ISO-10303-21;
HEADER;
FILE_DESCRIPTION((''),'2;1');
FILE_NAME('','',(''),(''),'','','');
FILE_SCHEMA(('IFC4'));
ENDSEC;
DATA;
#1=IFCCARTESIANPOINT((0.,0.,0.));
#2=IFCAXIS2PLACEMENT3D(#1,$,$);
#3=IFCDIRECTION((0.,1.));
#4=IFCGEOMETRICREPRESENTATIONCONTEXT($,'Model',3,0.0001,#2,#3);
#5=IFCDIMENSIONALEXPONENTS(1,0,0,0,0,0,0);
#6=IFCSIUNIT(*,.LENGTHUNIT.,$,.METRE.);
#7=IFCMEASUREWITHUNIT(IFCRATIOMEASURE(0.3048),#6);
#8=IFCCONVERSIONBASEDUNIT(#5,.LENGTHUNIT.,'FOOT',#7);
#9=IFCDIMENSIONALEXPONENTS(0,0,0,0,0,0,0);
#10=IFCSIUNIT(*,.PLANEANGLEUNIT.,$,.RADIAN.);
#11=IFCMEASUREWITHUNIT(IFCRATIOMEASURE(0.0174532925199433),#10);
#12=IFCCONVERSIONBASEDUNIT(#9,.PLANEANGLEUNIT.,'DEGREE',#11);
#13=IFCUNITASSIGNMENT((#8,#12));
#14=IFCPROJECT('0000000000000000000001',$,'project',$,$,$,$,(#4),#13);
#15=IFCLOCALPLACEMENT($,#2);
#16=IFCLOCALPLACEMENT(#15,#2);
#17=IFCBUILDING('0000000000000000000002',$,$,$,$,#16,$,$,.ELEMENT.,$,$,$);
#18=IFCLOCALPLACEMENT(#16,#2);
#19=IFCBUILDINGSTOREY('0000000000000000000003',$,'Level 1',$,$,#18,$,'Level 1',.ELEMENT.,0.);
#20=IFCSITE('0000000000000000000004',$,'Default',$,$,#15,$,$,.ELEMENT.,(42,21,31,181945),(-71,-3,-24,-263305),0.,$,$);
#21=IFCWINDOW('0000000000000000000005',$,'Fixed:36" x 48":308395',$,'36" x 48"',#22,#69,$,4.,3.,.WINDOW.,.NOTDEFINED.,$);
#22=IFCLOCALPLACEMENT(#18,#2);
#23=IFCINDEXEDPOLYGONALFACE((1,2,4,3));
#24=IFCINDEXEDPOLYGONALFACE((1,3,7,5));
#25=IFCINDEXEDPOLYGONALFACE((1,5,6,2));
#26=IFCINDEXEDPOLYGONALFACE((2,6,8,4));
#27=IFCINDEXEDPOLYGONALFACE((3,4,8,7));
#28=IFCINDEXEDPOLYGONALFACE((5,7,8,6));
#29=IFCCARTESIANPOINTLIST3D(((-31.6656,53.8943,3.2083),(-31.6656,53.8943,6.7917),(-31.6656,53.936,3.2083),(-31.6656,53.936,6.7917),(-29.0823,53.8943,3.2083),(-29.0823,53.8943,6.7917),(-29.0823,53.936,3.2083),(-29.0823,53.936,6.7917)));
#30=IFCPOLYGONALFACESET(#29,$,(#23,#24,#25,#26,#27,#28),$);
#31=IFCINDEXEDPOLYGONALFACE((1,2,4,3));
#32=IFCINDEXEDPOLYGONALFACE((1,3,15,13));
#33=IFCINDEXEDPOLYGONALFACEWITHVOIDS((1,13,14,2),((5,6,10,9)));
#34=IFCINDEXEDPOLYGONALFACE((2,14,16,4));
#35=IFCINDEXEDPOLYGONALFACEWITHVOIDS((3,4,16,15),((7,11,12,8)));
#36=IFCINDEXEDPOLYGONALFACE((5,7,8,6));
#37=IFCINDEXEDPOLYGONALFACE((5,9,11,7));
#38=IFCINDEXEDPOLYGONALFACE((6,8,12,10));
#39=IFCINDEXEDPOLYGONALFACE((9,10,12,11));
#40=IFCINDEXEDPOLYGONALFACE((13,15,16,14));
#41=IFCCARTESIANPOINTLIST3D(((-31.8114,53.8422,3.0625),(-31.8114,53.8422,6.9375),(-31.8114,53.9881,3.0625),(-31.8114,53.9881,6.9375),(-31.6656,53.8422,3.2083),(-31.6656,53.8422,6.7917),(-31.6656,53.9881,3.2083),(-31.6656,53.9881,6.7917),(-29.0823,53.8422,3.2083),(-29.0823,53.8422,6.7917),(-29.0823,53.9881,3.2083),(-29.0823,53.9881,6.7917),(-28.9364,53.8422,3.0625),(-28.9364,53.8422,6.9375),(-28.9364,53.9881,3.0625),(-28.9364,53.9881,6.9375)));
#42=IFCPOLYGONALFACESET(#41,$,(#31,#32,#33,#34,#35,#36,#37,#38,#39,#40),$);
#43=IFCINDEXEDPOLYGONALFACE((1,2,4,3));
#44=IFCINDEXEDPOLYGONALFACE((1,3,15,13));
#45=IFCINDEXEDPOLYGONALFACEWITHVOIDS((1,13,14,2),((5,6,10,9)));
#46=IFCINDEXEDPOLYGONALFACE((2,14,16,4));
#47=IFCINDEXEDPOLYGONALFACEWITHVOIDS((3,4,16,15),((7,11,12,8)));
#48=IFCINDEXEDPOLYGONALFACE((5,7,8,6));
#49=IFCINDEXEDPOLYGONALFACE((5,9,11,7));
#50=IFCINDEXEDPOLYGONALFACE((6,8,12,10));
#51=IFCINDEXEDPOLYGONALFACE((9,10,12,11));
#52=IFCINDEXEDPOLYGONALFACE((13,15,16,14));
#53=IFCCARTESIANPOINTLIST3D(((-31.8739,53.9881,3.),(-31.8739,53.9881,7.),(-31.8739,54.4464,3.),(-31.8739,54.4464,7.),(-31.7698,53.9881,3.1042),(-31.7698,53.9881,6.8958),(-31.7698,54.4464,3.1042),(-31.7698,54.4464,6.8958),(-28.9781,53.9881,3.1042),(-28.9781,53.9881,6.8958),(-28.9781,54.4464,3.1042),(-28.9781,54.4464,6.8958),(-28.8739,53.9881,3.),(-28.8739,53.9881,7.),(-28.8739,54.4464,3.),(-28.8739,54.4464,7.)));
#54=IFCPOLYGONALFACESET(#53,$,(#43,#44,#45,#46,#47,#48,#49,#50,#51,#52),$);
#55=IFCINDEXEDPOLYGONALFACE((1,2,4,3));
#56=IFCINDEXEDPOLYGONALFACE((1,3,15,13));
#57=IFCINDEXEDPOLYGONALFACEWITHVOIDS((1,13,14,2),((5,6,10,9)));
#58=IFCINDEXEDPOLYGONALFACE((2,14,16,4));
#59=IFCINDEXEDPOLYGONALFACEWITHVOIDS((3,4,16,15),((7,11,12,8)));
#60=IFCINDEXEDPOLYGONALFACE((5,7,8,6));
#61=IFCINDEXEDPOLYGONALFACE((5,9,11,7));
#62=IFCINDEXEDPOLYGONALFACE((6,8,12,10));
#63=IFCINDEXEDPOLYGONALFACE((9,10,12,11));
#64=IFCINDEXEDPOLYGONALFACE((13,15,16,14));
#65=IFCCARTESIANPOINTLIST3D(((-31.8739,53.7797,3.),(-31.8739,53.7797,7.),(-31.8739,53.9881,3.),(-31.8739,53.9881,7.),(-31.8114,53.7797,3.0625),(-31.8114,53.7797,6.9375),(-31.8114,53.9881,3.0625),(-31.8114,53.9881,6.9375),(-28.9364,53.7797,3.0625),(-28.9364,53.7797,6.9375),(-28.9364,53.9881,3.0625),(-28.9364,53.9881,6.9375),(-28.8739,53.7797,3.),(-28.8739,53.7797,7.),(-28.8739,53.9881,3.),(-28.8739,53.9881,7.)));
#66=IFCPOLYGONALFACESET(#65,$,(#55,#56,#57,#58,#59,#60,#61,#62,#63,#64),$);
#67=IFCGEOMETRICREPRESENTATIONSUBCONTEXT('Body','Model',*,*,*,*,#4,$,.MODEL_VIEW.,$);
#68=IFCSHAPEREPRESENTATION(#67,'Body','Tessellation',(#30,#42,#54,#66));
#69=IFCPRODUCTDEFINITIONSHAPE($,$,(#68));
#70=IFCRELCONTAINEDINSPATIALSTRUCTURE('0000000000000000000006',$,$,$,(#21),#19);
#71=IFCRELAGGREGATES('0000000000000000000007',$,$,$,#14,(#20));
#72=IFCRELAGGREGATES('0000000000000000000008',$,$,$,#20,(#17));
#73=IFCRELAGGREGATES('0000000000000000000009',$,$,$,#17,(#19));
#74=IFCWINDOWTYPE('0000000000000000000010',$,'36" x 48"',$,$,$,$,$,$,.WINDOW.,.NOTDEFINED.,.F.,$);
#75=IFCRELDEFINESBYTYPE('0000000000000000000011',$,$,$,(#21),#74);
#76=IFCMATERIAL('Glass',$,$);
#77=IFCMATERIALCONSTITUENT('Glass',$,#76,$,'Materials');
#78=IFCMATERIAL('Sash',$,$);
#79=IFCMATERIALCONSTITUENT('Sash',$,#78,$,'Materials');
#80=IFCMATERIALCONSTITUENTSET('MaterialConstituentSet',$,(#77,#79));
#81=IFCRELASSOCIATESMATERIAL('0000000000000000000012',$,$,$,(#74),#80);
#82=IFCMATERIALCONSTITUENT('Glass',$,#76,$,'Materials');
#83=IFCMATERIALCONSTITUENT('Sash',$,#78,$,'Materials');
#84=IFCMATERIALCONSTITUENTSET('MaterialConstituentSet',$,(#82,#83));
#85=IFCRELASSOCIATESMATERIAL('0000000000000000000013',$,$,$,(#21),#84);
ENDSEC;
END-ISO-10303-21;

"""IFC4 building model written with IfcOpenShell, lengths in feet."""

from ifc_helpers import new_model, entity, si_unit, converted_unit, direction, frame, frame_2d, origin, place, context, subcontext, project, spatial, polyline, rectangle, outline, extrude, source, transform, mapped, material, constituent, constituent_set, type_object, type_shapes, element, save


model = new_model("IFC4")

# Units and contexts
model_context = context("Model", 3, precision=0.0001, world=origin(), true_north=direction((0.0, 1.0)))
body_context = subcontext(model_context, "Body", "Model", "MODEL_VIEW")
ifc_project = project(units=[converted_unit("LENGTHUNIT", "FOOT", entity("IfcRatioMeasure", 0.3048), si_unit("LENGTHUNIT", "METRE"), dimensions=[1, 0, 0, 0, 0, 0, 0]), converted_unit("PLANEANGLEUNIT", "DEGREE", entity("IfcRatioMeasure", 0.0174532925199433), si_unit("PLANEANGLEUNIT", "RADIAN"), dimensions=[0, 0, 0, 0, 0, 0, 0])], contexts=[model_context])

# Site, building, storey
site_placement = place(None, origin())
site = spatial("IfcSite", under=ifc_project, at=site_placement, Name="Default", CompositionType="ELEMENT", RefLatitude=(42, 21, 31, 181945), RefLongitude=(-71, -3, -24, -263305), RefElevation=0.0)
building_placement = place(site_placement, origin())
building = spatial("IfcBuilding", under=site, at=building_placement, CompositionType="ELEMENT")
storey_placement = place(building_placement, origin())
storey = spatial("IfcBuildingStorey", under=building, at=storey_placement, Name="Level 1", LongName="Level 1", CompositionType="ELEMENT", Elevation=0.0)

# Shared definitions
placement_1 = place(storey_placement, frame((-39.4573, 54.1131, 0.0)))

# Window
ifc_material_1 = material(Name="Glass")
ifc_constituent_1 = constituent(ifc_material_1, Name="Glass", Category="Materials")
ifc_material_2 = material(Name="Sash")
ifc_constituent_2 = constituent(ifc_material_2, Name="Sash", Category="Materials")
ifc_constituent_set_1 = constituent_set(constituents=[ifc_constituent_1, ifc_constituent_2], Name="MaterialConstituentSet")
ifc_constituent_3 = constituent(ifc_material_1, Name="Glass", Category="Materials")
ifc_constituent_4 = constituent(ifc_material_2, Name="Sash", Category="Materials")
ifc_constituent_set_2 = constituent_set(constituents=[ifc_constituent_3, ifc_constituent_4], Name="MaterialConstituentSet")
window_type = type_object("IfcWindowType", Name="36\" x 48\"", ParameterTakesPrecedence=False, PartitioningType="NOTDEFINED", PredefinedType="WINDOW", material=ifc_constituent_set_2)
shared_shape = source(origin(), body_context, "Body", "SweptSolid", [
    extrude(rectangle(XDim=0.0417, YDim=2.5833, at=frame_2d((0.0, 0.0), x_axis=(1.0, 0.0))), frame((1.5, 0.5312, 0.2083), z_axis=(0.0, 0.0, 1.0), x_axis=(0.0, 1.0, 0.0)), (0.0, 0.0, 1.0), 3.5833),
    extrude(outline(polyline([(-1.4375, -1.9375), (1.4375, -1.9375), (1.4375, 1.9375), (-1.4375, 1.9375), (-1.4375, -1.9375)]), holes=[polyline([(-1.2917, -1.7917), (-1.2917, 1.7917), (1.2917, 1.7917), (1.2917, -1.7917), (-1.2917, -1.7917)])]), frame((1.5, 0.4583, 2.0), z_axis=(0.0, 1.0, 0.0), x_axis=(1.0, 0.0, 0.0)), (0.0, 0.0, 1.0), 0.1458),
    extrude(outline(polyline([(-1.5, -2.0), (1.5, -2.0), (1.5, 2.0), (-1.5, 2.0), (-1.5, -2.0)]), holes=[polyline([(-1.3958, -1.8958), (-1.3958, 1.8958), (1.3958, 1.8958), (1.3958, -1.8958), (-1.3958, -1.8958)])]), frame((1.5, 0.0, 2.0), z_axis=(0.0, 1.0, 0.0), x_axis=(1.0, 0.0, 0.0)), (0.0, 0.0, 1.0), 0.4583),
    extrude(outline(polyline([(-2.0, -1.5), (2.0, -1.5), (2.0, 1.5), (-2.0, 1.5), (-2.0, -1.5)]), holes=[polyline([(-1.9375, -1.4375), (-1.9375, 1.4375), (1.9375, 1.4375), (1.9375, -1.4375), (-1.9375, -1.4375)])]), frame((1.5, 0.4583, 2.0), z_axis=(0.0, 1.0, 0.0), x_axis=(0.0, 0.0, -1.0)), (0.0, 0.0, 1.0), 0.2083),
])
type_shapes(window_type, [shared_shape])
placement_2 = place(placement_1, frame((10.5833, 0.3333, 3.0)))
window_placement = place(placement_2, frame((0.0, 0.0, 0.0), z_axis=(0.0, 0.0, 1.0), x_axis=(-1.0, 0.0, 0.0)))
element("IfcWindow", 1, at=window_placement, inside=storey, type_object=window_type, material=ifc_constituent_set_1, Name="Fixed:36\" x 48\":308395", ObjectType="36\" x 48\"", OverallHeight=4.0, OverallWidth=3.0, PartitioningType="NOTDEFINED", PredefinedType="WINDOW", context=body_context, shape_type="MappedRepresentation", body=[
    mapped(shared_shape, transform((0.0, 0.0, 0.0), scale=1.0)),
])

save(model, "model.ifc")
